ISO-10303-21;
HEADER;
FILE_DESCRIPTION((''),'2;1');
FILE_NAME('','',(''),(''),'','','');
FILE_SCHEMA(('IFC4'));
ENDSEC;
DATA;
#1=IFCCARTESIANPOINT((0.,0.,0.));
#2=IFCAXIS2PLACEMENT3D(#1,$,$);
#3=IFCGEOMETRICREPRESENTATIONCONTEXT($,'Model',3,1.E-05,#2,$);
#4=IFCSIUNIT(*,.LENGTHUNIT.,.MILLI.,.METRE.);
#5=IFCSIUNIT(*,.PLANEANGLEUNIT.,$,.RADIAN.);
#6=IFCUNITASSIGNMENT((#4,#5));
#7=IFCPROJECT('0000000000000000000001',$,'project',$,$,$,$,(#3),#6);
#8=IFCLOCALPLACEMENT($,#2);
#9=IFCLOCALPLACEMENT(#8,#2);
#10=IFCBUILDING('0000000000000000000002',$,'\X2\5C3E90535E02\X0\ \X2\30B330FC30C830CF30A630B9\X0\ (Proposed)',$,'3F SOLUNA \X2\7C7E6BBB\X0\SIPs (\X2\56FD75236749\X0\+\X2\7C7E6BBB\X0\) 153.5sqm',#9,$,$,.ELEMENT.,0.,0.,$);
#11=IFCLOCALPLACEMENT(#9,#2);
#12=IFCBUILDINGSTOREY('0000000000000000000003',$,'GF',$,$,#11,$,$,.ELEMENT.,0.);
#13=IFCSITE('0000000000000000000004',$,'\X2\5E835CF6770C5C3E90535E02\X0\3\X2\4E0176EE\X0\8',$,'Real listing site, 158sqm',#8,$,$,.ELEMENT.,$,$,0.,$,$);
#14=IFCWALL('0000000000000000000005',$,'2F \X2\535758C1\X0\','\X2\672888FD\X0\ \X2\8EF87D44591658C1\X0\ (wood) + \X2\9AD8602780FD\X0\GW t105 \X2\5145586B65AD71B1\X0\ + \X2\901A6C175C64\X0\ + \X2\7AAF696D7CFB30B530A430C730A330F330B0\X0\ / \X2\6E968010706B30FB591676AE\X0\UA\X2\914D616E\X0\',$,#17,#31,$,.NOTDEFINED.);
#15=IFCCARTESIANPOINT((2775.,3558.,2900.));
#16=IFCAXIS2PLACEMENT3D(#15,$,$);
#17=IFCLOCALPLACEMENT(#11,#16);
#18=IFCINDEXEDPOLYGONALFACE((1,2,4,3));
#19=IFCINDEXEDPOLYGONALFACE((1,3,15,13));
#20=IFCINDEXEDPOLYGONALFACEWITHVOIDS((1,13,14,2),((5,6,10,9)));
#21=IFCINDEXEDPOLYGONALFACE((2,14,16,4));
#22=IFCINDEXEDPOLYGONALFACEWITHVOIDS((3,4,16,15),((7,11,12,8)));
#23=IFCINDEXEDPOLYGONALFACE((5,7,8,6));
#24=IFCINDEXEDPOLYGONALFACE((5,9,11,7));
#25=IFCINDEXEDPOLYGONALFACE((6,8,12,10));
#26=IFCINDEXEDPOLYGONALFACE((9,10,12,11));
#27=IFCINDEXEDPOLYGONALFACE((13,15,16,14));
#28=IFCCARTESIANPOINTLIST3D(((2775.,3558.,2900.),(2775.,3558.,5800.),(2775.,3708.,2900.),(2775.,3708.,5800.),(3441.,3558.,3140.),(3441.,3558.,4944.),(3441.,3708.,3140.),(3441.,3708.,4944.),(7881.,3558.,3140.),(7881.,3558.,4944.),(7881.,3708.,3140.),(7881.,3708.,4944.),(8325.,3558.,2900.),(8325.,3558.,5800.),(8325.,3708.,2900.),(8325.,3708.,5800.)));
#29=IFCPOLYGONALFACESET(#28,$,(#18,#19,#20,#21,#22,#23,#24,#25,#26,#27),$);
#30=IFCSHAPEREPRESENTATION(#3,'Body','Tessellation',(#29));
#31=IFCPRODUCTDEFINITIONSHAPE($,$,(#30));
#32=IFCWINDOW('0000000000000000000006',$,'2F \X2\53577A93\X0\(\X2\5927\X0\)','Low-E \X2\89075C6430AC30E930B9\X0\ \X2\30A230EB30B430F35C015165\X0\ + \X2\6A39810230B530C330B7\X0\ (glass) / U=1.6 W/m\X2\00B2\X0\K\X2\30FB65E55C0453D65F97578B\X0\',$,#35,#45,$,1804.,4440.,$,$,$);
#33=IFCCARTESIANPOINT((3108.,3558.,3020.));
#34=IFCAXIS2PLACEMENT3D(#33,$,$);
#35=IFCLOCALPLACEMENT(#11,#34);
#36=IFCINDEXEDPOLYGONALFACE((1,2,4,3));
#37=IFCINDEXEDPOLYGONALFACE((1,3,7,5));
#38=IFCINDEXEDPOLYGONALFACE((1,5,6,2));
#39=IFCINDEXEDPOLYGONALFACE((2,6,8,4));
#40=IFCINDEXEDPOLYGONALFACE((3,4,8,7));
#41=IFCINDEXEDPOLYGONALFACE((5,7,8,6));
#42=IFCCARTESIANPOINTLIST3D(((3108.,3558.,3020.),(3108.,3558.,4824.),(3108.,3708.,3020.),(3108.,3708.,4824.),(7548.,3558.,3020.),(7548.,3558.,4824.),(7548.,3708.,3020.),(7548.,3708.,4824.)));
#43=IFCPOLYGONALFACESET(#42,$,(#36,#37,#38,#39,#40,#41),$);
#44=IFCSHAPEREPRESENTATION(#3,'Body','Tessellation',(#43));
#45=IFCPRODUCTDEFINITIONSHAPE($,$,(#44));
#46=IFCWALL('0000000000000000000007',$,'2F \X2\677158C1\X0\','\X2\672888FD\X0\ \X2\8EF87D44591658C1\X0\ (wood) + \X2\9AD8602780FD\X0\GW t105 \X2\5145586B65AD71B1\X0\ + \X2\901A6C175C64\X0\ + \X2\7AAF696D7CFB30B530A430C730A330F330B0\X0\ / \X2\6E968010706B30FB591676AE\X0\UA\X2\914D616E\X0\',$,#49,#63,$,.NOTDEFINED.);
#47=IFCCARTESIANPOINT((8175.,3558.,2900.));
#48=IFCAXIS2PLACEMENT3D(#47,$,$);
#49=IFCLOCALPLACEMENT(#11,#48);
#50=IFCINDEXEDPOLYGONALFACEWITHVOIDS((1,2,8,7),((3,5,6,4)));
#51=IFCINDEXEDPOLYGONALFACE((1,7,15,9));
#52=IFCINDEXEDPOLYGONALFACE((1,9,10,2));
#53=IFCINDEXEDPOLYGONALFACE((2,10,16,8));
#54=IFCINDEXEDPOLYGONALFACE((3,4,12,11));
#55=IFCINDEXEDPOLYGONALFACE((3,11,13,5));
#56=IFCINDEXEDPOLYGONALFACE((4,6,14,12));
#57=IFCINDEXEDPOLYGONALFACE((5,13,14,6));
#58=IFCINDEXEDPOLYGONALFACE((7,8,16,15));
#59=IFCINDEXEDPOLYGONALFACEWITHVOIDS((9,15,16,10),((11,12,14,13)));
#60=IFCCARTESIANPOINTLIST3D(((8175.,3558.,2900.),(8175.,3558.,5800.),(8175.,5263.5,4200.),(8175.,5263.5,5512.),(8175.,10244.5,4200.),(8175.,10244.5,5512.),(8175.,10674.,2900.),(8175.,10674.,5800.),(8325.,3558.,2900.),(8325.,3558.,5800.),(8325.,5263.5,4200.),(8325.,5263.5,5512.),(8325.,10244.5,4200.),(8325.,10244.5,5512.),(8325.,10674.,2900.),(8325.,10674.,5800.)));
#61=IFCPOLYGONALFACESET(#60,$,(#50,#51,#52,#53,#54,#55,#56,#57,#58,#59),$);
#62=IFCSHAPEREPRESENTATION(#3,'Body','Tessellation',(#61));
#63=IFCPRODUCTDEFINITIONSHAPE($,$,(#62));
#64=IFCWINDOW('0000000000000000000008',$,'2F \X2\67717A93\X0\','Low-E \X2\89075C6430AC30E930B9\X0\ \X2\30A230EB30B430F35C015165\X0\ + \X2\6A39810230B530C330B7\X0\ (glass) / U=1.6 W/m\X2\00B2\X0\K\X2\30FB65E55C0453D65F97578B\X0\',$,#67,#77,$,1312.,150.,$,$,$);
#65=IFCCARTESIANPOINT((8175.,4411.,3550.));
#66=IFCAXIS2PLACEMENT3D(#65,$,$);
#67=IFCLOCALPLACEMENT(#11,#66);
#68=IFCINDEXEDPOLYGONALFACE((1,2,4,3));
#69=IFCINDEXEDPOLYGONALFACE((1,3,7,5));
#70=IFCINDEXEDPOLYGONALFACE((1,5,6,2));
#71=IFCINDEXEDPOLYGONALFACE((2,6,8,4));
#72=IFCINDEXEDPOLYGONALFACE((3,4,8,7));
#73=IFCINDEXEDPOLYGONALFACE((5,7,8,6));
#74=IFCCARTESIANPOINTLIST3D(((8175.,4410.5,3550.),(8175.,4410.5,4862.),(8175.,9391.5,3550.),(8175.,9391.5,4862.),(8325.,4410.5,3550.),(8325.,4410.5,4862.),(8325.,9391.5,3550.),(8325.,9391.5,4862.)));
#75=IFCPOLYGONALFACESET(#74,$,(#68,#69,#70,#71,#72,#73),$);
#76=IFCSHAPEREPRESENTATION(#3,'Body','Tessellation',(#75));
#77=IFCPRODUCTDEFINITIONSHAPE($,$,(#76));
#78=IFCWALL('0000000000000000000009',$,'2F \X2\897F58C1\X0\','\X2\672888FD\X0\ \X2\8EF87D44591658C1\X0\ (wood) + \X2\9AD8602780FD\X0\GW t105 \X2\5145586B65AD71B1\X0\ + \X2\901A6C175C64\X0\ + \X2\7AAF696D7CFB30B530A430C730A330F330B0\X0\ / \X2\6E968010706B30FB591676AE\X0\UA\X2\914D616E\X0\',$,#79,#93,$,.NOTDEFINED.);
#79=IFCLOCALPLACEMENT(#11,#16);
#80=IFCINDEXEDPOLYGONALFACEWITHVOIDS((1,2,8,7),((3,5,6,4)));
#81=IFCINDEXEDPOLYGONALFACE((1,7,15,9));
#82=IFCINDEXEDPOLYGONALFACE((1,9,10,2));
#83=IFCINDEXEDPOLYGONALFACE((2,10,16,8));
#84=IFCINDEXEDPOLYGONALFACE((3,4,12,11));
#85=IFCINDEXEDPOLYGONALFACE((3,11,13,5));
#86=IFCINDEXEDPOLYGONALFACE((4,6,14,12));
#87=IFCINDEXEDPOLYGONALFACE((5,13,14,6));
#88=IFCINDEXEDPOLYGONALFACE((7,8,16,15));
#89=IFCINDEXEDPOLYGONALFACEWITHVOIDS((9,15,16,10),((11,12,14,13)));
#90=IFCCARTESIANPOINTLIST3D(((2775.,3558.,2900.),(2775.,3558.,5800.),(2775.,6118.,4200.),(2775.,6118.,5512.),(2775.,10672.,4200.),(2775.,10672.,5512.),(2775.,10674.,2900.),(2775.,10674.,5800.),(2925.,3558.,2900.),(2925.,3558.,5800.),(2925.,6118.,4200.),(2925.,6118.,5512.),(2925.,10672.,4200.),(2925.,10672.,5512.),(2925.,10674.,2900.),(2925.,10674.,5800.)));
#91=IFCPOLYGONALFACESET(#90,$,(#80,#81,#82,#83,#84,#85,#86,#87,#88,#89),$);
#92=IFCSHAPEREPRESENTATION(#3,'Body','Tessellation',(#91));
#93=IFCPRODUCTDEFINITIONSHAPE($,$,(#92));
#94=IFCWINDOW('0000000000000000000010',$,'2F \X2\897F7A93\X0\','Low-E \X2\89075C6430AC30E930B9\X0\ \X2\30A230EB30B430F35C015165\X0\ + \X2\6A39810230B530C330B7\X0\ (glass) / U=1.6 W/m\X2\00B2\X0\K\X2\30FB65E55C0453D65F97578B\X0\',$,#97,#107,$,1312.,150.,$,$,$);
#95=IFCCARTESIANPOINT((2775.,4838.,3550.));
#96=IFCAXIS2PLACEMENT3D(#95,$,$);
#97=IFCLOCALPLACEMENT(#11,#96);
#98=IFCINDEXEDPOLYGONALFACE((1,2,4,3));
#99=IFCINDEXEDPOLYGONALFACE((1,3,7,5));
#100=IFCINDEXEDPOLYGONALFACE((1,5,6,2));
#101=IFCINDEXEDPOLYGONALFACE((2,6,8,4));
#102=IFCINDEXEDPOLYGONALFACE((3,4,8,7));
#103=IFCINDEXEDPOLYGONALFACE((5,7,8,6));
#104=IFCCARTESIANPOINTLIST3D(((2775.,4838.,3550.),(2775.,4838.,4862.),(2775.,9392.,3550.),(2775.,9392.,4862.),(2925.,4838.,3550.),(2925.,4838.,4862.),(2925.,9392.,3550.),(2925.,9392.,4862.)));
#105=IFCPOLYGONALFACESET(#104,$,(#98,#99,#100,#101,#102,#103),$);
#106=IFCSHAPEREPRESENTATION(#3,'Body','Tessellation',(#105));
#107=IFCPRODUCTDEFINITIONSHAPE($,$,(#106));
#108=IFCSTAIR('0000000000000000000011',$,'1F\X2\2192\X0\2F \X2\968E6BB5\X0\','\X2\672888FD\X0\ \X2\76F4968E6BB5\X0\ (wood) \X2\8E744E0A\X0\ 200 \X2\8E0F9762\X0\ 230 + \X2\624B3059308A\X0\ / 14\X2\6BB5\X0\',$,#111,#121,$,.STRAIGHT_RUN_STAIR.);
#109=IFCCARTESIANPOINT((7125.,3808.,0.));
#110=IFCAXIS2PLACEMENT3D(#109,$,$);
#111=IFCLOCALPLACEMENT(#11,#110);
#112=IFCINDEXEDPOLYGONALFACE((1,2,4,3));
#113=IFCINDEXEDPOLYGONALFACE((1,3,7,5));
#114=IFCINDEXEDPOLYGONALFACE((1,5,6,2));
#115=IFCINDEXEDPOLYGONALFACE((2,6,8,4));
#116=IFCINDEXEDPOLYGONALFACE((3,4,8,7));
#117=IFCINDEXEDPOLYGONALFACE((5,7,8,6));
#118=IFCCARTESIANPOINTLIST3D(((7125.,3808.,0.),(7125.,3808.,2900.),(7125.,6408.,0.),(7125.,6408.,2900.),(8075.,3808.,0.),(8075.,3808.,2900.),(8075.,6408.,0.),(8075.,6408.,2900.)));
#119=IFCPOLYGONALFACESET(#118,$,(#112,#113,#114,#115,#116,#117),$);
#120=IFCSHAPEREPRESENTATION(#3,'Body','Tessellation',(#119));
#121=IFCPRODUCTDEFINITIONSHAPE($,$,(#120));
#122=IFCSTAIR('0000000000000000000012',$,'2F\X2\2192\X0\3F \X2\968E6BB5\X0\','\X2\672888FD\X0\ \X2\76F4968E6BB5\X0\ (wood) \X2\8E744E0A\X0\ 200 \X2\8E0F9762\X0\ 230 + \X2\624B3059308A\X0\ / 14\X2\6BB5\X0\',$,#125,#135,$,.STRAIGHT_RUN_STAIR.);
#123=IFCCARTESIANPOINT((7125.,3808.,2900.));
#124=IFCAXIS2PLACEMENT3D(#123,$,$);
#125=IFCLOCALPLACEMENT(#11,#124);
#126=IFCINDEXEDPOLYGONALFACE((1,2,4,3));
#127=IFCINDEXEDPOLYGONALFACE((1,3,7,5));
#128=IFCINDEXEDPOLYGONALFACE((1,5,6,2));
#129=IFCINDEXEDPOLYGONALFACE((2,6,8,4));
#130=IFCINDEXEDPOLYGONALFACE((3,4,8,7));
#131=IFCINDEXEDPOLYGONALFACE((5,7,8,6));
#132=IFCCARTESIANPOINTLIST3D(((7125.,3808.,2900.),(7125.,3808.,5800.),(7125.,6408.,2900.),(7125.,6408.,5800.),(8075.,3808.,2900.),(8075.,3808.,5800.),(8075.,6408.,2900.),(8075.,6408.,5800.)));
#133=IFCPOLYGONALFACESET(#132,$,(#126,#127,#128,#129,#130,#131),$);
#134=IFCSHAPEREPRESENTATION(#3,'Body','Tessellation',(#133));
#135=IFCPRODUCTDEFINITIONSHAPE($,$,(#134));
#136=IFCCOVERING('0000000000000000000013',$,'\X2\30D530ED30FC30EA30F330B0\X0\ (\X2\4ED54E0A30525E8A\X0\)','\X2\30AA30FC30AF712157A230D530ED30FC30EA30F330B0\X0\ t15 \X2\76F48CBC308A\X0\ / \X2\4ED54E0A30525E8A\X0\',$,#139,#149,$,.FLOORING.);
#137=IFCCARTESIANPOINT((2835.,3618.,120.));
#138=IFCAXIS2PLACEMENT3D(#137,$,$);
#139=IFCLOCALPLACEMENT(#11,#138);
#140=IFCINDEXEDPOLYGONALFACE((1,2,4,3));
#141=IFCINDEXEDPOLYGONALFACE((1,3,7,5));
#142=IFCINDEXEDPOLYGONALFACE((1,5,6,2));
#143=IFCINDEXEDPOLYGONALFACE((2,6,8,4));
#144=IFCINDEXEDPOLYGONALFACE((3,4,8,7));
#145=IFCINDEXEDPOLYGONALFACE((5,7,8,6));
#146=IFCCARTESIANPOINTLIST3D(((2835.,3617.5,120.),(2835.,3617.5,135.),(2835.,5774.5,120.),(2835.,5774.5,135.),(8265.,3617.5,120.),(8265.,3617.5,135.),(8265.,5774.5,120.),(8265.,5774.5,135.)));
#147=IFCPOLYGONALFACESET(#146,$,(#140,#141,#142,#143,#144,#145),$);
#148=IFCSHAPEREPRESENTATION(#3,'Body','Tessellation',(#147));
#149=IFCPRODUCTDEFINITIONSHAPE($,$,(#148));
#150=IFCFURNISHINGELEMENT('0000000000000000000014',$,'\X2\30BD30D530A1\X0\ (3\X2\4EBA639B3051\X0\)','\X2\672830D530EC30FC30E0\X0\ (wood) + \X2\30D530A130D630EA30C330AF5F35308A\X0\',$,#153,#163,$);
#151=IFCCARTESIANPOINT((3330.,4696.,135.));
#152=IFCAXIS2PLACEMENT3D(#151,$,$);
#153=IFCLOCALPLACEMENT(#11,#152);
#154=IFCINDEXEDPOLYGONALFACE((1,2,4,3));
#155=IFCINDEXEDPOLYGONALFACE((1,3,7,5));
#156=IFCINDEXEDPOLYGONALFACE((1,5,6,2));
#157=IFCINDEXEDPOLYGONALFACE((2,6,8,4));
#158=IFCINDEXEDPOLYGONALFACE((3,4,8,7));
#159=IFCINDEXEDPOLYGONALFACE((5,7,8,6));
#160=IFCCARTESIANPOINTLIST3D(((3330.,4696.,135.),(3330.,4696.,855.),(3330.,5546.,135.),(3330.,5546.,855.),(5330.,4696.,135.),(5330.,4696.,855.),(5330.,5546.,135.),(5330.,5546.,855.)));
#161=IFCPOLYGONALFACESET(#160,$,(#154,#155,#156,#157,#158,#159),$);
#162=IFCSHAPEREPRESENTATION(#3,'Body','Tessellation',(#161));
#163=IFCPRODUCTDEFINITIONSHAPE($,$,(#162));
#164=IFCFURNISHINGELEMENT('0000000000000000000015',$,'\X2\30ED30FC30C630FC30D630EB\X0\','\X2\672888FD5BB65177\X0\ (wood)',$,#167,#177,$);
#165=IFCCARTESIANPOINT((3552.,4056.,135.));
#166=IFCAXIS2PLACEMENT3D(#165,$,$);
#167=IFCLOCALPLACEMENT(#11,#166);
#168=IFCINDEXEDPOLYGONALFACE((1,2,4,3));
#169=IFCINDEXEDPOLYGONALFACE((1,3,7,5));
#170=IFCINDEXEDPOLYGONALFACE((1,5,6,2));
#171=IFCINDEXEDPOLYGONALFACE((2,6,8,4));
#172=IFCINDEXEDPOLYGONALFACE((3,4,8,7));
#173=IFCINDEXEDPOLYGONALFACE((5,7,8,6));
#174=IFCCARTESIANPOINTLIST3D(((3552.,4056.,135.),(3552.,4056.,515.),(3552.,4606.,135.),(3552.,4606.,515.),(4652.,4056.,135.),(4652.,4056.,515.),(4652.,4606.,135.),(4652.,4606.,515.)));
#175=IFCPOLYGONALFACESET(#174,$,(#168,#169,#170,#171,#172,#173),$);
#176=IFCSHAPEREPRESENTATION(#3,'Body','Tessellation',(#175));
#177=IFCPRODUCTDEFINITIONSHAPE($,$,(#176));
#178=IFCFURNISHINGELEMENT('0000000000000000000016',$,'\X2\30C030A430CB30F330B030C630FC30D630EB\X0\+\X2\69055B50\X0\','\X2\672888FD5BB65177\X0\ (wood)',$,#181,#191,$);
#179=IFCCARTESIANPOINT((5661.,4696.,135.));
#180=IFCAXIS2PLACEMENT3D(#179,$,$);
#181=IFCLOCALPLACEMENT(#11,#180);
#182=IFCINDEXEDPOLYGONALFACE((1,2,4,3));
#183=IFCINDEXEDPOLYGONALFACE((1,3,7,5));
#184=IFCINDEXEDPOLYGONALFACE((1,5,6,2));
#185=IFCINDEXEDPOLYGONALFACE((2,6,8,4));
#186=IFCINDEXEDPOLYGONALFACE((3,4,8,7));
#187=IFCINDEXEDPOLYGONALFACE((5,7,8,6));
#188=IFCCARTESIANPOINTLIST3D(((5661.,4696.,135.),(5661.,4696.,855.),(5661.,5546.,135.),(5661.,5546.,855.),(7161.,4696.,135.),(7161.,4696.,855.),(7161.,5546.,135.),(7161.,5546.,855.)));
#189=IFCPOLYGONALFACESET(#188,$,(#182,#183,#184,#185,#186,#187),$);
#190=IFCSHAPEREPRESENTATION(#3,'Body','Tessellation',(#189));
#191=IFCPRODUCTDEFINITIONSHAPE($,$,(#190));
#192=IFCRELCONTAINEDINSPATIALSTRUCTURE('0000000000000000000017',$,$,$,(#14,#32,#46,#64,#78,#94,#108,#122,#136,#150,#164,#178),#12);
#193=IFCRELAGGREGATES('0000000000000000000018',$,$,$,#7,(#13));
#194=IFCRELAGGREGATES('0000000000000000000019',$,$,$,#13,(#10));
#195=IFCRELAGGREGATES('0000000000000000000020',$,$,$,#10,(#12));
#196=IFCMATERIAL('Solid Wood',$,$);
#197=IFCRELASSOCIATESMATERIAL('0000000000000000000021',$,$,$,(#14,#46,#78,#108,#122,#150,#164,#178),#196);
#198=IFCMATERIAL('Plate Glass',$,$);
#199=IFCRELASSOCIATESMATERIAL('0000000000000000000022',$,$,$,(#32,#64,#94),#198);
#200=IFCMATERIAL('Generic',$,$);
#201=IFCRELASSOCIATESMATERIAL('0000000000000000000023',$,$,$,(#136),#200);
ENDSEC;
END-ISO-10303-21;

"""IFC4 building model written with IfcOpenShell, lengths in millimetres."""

from ifc_helpers import new_model, si_unit, frame, frame_2d, origin, place, context, project, spatial, rectangle, extrude, material, element, fill, save


model = new_model("IFC4")

# Units and contexts
model_context = context("Model", 3, precision=1e-05, world=origin())
ifc_project = project(units=[si_unit("LENGTHUNIT", "METRE", prefix="MILLI"), si_unit("PLANEANGLEUNIT", "RADIAN")], contexts=[model_context])

# Site, building, storey
site_placement = place(None, origin())
site = spatial("IfcSite", under=ifc_project, at=site_placement, Name="広島県尾道市3丁目8", ObjectType="Real listing site, 158sqm", CompositionType="ELEMENT", RefElevation=0.0)
building_placement = place(site_placement, origin())
building = spatial("IfcBuilding", under=site, at=building_placement, Name="尾道市 コートハウス (Proposed)", ObjectType="3F SOLUNA 籾殻SIPs (国産杉+籾殻) 153.5sqm", CompositionType="ELEMENT", ElevationOfRefHeight=0.0, ElevationOfTerrain=0.0)
storey_placement = place(building_placement, origin())
storey = spatial("IfcBuildingStorey", under=building, at=storey_placement, Name="GF", CompositionType="ELEMENT", Elevation=0.0)

# Shared definitions
ifc_material_1 = material(Name="Solid Wood")
ifc_material_2 = material(Name="Generic")

# Shared definitions
ifc_material_3 = material(Name="Plate Glass")

# Walls, openings, windows
wall_1_placement = place(storey_placement, frame((2775.0, 3558.0, 2900.0)))
wall_1 = element("IfcWall", 1, at=wall_1_placement, inside=storey, material=ifc_material_1, Name="2F 南壁", Description="木製 軸組外壁 (wood) + 高性能GW t105 充填断熱 + 通気層 + 窯業系サイディング / 準耐火・外皮UA配慮", PredefinedType="NOTDEFINED", context=model_context, shape_type="SweptSolid", body=[
    extrude(rectangle(XDim=5550.0, YDim=150.0, at=frame_2d((2775.0, 75.0))), frame((2775.0, 3558.0, 2900.0)), (0.0, 0.0, 1.0), 2900.0),
])
opening_1_placement = place(storey_placement, frame((3108.0, 3558.0, 3020.0)))
opening_1 = element("IfcOpeningElement", 2, at=opening_1_placement, cuts=wall_1, PredefinedType="NOTDEFINED", context=model_context, shape_type="SweptSolid", body=[
    extrude(rectangle(XDim=4440.0, YDim=150.0, at=frame_2d((2220.0, 75.0))), frame((3108.0, 3558.0, 3020.0)), (0.0, 0.0, 1.0), 1804.0),
])
window_1_placement = place(storey_placement, frame((3108.0, 3558.0, 3020.0)))
window_1 = element("IfcWindow", 3, at=window_1_placement, inside=storey, material=ifc_material_3, Name="2F 南窓(大)", Description="Low-E 複層ガラス アルゴン封入 + 樹脂サッシ (glass) / U=1.6 W/m²K・日射取得型", OverallHeight=1804.0, OverallWidth=4440.0, context=model_context, shape_type="SweptSolid", body=[
    extrude(rectangle(XDim=4440.0, YDim=150.0, at=frame_2d((2220.0, 75.0))), frame((3108.0, 3558.0, 3020.0)), (0.0, 0.0, 1.0), 1804.0),
])
fill(opening_1, window_1)
wall_2_placement = place(storey_placement, frame((8175.0, 3558.0, 2900.0)))
wall_2 = element("IfcWall", 4, at=wall_2_placement, inside=storey, material=ifc_material_1, Name="2F 東壁", Description="木製 軸組外壁 (wood) + 高性能GW t105 充填断熱 + 通気層 + 窯業系サイディング / 準耐火・外皮UA配慮", PredefinedType="NOTDEFINED", context=model_context, shape_type="SweptSolid", body=[
    extrude(rectangle(XDim=150.0, YDim=7116.0, at=frame_2d((75.0, 3558.0))), frame((8175.0, 3558.0, 2900.0)), (0.0, 0.0, 1.0), 2900.0),
])
opening_2_placement = place(storey_placement, frame((8175.0, 4411.0, 3550.0)))
opening_2 = element("IfcOpeningElement", 5, at=opening_2_placement, cuts=wall_2, PredefinedType="NOTDEFINED", context=model_context, shape_type="SweptSolid", body=[
    extrude(rectangle(XDim=150.0, YDim=4981.0, at=frame_2d((75.0, 2490.0))), frame((8175.0, 4411.0, 3550.0)), (0.0, 0.0, 1.0), 1312.0),
])
window_2_placement = place(storey_placement, frame((8175.0, 4411.0, 3550.0)))
window_2 = element("IfcWindow", 6, at=window_2_placement, inside=storey, material=ifc_material_3, Name="2F 東窓", Description="Low-E 複層ガラス アルゴン封入 + 樹脂サッシ (glass) / U=1.6 W/m²K・日射取得型", OverallHeight=1312.0, OverallWidth=150.0, context=model_context, shape_type="SweptSolid", body=[
    extrude(rectangle(XDim=150.0, YDim=4981.0, at=frame_2d((75.0, 2490.0))), frame((8175.0, 4411.0, 3550.0)), (0.0, 0.0, 1.0), 1312.0),
])
fill(opening_2, window_2)
wall_3_placement = place(storey_placement, frame((2775.0, 3558.0, 2900.0)))
wall_3 = element("IfcWall", 7, at=wall_3_placement, inside=storey, material=ifc_material_1, Name="2F 西壁", Description="木製 軸組外壁 (wood) + 高性能GW t105 充填断熱 + 通気層 + 窯業系サイディング / 準耐火・外皮UA配慮", PredefinedType="NOTDEFINED", context=model_context, shape_type="SweptSolid", body=[
    extrude(rectangle(XDim=150.0, YDim=7116.0, at=frame_2d((75.0, 3558.0))), frame((2775.0, 3558.0, 2900.0)), (0.0, 0.0, 1.0), 2900.0),
])
opening_3_placement = place(storey_placement, frame((2775.0, 4838.0, 3550.0)))
opening_3 = element("IfcOpeningElement", 8, at=opening_3_placement, cuts=wall_3, PredefinedType="NOTDEFINED", context=model_context, shape_type="SweptSolid", body=[
    extrude(rectangle(XDim=150.0, YDim=4554.0, at=frame_2d((75.0, 2277.0))), frame((2775.0, 4838.0, 3550.0)), (0.0, 0.0, 1.0), 1312.0),
])
window_3_placement = place(storey_placement, frame((2775.0, 4838.0, 3550.0)))
window_3 = element("IfcWindow", 9, at=window_3_placement, inside=storey, material=ifc_material_3, Name="2F 西窓", Description="Low-E 複層ガラス アルゴン封入 + 樹脂サッシ (glass) / U=1.6 W/m²K・日射取得型", OverallHeight=1312.0, OverallWidth=150.0, context=model_context, shape_type="SweptSolid", body=[
    extrude(rectangle(XDim=150.0, YDim=4554.0, at=frame_2d((75.0, 2277.0))), frame((2775.0, 4838.0, 3550.0)), (0.0, 0.0, 1.0), 1312.0),
])
fill(opening_3, window_3)

# Stairs
stair_1_placement = place(storey_placement, frame((7125.0, 3808.0, 0.0)))
element("IfcStair", 10, at=stair_1_placement, inside=storey, material=ifc_material_1, Name="1F→2F 階段", Description="木製 直階段 (wood) 蹴上 200 踏面 230 + 手すり / 14段", PredefinedType="STRAIGHT_RUN_STAIR", context=model_context, shape_type="SweptSolid", body=[
    extrude(rectangle(XDim=950.0, YDim=2600.0, at=frame_2d((475.0, 1300.0))), frame((7125.0, 3808.0, 0.0)), (0.0, 0.0, 1.0), 2900.0),
])
stair_2_placement = place(storey_placement, frame((7125.0, 3808.0, 2900.0)))
element("IfcStair", 11, at=stair_2_placement, inside=storey, material=ifc_material_1, Name="2F→3F 階段", Description="木製 直階段 (wood) 蹴上 200 踏面 230 + 手すり / 14段", PredefinedType="STRAIGHT_RUN_STAIR", context=model_context, shape_type="SweptSolid", body=[
    extrude(rectangle(XDim=950.0, YDim=2600.0, at=frame_2d((475.0, 1300.0))), frame((7125.0, 3808.0, 2900.0)), (0.0, 0.0, 1.0), 2900.0),
])

# Covering
covering_placement = place(storey_placement, frame((2835.0, 3618.0, 120.0)))
element("IfcCovering", 12, at=covering_placement, inside=storey, material=ifc_material_2, Name="フローリング (仕上げ床)", Description="オーク無垢フローリング t15 直貼り / 仕上げ床", PredefinedType="FLOORING", context=model_context, shape_type="SweptSolid", body=[
    extrude(rectangle(XDim=5430.0, YDim=2157.0, at=frame_2d((2715.0, 1078.0))), frame((2835.0, 3618.0, 120.0)), (0.0, 0.0, 1.0), 15.0),
])

# Furnishing elements
furnishing_1_placement = place(storey_placement, frame((3330.0, 4696.0, 135.0)))
element("IfcFurnishingElement", 13, at=furnishing_1_placement, inside=storey, material=ifc_material_1, Name="ソファ (3人掛け)", Description="木フレーム (wood) + ファブリック張り", context=model_context, shape_type="SweptSolid", body=[
    extrude(rectangle(XDim=2000.0, YDim=850.0, at=frame_2d((1000.0, 425.0))), frame((3330.0, 4696.0, 135.0)), (0.0, 0.0, 1.0), 720.0),
])
furnishing_2_placement = place(storey_placement, frame((3552.0, 4056.0, 135.0)))
element("IfcFurnishingElement", 14, at=furnishing_2_placement, inside=storey, material=ifc_material_1, Name="ローテーブル", Description="木製家具 (wood)", context=model_context, shape_type="SweptSolid", body=[
    extrude(rectangle(XDim=1100.0, YDim=550.0, at=frame_2d((550.0, 275.0))), frame((3552.0, 4056.0, 135.0)), (0.0, 0.0, 1.0), 380.0),
])
furnishing_3_placement = place(storey_placement, frame((5661.0, 4696.0, 135.0)))
element("IfcFurnishingElement", 15, at=furnishing_3_placement, inside=storey, material=ifc_material_1, Name="ダイニングテーブル+椅子", Description="木製家具 (wood)", context=model_context, shape_type="SweptSolid", body=[
    extrude(rectangle(XDim=1500.0, YDim=850.0, at=frame_2d((750.0, 425.0))), frame((5661.0, 4696.0, 135.0)), (0.0, 0.0, 1.0), 720.0),
])

save(model, "model.ifc")
